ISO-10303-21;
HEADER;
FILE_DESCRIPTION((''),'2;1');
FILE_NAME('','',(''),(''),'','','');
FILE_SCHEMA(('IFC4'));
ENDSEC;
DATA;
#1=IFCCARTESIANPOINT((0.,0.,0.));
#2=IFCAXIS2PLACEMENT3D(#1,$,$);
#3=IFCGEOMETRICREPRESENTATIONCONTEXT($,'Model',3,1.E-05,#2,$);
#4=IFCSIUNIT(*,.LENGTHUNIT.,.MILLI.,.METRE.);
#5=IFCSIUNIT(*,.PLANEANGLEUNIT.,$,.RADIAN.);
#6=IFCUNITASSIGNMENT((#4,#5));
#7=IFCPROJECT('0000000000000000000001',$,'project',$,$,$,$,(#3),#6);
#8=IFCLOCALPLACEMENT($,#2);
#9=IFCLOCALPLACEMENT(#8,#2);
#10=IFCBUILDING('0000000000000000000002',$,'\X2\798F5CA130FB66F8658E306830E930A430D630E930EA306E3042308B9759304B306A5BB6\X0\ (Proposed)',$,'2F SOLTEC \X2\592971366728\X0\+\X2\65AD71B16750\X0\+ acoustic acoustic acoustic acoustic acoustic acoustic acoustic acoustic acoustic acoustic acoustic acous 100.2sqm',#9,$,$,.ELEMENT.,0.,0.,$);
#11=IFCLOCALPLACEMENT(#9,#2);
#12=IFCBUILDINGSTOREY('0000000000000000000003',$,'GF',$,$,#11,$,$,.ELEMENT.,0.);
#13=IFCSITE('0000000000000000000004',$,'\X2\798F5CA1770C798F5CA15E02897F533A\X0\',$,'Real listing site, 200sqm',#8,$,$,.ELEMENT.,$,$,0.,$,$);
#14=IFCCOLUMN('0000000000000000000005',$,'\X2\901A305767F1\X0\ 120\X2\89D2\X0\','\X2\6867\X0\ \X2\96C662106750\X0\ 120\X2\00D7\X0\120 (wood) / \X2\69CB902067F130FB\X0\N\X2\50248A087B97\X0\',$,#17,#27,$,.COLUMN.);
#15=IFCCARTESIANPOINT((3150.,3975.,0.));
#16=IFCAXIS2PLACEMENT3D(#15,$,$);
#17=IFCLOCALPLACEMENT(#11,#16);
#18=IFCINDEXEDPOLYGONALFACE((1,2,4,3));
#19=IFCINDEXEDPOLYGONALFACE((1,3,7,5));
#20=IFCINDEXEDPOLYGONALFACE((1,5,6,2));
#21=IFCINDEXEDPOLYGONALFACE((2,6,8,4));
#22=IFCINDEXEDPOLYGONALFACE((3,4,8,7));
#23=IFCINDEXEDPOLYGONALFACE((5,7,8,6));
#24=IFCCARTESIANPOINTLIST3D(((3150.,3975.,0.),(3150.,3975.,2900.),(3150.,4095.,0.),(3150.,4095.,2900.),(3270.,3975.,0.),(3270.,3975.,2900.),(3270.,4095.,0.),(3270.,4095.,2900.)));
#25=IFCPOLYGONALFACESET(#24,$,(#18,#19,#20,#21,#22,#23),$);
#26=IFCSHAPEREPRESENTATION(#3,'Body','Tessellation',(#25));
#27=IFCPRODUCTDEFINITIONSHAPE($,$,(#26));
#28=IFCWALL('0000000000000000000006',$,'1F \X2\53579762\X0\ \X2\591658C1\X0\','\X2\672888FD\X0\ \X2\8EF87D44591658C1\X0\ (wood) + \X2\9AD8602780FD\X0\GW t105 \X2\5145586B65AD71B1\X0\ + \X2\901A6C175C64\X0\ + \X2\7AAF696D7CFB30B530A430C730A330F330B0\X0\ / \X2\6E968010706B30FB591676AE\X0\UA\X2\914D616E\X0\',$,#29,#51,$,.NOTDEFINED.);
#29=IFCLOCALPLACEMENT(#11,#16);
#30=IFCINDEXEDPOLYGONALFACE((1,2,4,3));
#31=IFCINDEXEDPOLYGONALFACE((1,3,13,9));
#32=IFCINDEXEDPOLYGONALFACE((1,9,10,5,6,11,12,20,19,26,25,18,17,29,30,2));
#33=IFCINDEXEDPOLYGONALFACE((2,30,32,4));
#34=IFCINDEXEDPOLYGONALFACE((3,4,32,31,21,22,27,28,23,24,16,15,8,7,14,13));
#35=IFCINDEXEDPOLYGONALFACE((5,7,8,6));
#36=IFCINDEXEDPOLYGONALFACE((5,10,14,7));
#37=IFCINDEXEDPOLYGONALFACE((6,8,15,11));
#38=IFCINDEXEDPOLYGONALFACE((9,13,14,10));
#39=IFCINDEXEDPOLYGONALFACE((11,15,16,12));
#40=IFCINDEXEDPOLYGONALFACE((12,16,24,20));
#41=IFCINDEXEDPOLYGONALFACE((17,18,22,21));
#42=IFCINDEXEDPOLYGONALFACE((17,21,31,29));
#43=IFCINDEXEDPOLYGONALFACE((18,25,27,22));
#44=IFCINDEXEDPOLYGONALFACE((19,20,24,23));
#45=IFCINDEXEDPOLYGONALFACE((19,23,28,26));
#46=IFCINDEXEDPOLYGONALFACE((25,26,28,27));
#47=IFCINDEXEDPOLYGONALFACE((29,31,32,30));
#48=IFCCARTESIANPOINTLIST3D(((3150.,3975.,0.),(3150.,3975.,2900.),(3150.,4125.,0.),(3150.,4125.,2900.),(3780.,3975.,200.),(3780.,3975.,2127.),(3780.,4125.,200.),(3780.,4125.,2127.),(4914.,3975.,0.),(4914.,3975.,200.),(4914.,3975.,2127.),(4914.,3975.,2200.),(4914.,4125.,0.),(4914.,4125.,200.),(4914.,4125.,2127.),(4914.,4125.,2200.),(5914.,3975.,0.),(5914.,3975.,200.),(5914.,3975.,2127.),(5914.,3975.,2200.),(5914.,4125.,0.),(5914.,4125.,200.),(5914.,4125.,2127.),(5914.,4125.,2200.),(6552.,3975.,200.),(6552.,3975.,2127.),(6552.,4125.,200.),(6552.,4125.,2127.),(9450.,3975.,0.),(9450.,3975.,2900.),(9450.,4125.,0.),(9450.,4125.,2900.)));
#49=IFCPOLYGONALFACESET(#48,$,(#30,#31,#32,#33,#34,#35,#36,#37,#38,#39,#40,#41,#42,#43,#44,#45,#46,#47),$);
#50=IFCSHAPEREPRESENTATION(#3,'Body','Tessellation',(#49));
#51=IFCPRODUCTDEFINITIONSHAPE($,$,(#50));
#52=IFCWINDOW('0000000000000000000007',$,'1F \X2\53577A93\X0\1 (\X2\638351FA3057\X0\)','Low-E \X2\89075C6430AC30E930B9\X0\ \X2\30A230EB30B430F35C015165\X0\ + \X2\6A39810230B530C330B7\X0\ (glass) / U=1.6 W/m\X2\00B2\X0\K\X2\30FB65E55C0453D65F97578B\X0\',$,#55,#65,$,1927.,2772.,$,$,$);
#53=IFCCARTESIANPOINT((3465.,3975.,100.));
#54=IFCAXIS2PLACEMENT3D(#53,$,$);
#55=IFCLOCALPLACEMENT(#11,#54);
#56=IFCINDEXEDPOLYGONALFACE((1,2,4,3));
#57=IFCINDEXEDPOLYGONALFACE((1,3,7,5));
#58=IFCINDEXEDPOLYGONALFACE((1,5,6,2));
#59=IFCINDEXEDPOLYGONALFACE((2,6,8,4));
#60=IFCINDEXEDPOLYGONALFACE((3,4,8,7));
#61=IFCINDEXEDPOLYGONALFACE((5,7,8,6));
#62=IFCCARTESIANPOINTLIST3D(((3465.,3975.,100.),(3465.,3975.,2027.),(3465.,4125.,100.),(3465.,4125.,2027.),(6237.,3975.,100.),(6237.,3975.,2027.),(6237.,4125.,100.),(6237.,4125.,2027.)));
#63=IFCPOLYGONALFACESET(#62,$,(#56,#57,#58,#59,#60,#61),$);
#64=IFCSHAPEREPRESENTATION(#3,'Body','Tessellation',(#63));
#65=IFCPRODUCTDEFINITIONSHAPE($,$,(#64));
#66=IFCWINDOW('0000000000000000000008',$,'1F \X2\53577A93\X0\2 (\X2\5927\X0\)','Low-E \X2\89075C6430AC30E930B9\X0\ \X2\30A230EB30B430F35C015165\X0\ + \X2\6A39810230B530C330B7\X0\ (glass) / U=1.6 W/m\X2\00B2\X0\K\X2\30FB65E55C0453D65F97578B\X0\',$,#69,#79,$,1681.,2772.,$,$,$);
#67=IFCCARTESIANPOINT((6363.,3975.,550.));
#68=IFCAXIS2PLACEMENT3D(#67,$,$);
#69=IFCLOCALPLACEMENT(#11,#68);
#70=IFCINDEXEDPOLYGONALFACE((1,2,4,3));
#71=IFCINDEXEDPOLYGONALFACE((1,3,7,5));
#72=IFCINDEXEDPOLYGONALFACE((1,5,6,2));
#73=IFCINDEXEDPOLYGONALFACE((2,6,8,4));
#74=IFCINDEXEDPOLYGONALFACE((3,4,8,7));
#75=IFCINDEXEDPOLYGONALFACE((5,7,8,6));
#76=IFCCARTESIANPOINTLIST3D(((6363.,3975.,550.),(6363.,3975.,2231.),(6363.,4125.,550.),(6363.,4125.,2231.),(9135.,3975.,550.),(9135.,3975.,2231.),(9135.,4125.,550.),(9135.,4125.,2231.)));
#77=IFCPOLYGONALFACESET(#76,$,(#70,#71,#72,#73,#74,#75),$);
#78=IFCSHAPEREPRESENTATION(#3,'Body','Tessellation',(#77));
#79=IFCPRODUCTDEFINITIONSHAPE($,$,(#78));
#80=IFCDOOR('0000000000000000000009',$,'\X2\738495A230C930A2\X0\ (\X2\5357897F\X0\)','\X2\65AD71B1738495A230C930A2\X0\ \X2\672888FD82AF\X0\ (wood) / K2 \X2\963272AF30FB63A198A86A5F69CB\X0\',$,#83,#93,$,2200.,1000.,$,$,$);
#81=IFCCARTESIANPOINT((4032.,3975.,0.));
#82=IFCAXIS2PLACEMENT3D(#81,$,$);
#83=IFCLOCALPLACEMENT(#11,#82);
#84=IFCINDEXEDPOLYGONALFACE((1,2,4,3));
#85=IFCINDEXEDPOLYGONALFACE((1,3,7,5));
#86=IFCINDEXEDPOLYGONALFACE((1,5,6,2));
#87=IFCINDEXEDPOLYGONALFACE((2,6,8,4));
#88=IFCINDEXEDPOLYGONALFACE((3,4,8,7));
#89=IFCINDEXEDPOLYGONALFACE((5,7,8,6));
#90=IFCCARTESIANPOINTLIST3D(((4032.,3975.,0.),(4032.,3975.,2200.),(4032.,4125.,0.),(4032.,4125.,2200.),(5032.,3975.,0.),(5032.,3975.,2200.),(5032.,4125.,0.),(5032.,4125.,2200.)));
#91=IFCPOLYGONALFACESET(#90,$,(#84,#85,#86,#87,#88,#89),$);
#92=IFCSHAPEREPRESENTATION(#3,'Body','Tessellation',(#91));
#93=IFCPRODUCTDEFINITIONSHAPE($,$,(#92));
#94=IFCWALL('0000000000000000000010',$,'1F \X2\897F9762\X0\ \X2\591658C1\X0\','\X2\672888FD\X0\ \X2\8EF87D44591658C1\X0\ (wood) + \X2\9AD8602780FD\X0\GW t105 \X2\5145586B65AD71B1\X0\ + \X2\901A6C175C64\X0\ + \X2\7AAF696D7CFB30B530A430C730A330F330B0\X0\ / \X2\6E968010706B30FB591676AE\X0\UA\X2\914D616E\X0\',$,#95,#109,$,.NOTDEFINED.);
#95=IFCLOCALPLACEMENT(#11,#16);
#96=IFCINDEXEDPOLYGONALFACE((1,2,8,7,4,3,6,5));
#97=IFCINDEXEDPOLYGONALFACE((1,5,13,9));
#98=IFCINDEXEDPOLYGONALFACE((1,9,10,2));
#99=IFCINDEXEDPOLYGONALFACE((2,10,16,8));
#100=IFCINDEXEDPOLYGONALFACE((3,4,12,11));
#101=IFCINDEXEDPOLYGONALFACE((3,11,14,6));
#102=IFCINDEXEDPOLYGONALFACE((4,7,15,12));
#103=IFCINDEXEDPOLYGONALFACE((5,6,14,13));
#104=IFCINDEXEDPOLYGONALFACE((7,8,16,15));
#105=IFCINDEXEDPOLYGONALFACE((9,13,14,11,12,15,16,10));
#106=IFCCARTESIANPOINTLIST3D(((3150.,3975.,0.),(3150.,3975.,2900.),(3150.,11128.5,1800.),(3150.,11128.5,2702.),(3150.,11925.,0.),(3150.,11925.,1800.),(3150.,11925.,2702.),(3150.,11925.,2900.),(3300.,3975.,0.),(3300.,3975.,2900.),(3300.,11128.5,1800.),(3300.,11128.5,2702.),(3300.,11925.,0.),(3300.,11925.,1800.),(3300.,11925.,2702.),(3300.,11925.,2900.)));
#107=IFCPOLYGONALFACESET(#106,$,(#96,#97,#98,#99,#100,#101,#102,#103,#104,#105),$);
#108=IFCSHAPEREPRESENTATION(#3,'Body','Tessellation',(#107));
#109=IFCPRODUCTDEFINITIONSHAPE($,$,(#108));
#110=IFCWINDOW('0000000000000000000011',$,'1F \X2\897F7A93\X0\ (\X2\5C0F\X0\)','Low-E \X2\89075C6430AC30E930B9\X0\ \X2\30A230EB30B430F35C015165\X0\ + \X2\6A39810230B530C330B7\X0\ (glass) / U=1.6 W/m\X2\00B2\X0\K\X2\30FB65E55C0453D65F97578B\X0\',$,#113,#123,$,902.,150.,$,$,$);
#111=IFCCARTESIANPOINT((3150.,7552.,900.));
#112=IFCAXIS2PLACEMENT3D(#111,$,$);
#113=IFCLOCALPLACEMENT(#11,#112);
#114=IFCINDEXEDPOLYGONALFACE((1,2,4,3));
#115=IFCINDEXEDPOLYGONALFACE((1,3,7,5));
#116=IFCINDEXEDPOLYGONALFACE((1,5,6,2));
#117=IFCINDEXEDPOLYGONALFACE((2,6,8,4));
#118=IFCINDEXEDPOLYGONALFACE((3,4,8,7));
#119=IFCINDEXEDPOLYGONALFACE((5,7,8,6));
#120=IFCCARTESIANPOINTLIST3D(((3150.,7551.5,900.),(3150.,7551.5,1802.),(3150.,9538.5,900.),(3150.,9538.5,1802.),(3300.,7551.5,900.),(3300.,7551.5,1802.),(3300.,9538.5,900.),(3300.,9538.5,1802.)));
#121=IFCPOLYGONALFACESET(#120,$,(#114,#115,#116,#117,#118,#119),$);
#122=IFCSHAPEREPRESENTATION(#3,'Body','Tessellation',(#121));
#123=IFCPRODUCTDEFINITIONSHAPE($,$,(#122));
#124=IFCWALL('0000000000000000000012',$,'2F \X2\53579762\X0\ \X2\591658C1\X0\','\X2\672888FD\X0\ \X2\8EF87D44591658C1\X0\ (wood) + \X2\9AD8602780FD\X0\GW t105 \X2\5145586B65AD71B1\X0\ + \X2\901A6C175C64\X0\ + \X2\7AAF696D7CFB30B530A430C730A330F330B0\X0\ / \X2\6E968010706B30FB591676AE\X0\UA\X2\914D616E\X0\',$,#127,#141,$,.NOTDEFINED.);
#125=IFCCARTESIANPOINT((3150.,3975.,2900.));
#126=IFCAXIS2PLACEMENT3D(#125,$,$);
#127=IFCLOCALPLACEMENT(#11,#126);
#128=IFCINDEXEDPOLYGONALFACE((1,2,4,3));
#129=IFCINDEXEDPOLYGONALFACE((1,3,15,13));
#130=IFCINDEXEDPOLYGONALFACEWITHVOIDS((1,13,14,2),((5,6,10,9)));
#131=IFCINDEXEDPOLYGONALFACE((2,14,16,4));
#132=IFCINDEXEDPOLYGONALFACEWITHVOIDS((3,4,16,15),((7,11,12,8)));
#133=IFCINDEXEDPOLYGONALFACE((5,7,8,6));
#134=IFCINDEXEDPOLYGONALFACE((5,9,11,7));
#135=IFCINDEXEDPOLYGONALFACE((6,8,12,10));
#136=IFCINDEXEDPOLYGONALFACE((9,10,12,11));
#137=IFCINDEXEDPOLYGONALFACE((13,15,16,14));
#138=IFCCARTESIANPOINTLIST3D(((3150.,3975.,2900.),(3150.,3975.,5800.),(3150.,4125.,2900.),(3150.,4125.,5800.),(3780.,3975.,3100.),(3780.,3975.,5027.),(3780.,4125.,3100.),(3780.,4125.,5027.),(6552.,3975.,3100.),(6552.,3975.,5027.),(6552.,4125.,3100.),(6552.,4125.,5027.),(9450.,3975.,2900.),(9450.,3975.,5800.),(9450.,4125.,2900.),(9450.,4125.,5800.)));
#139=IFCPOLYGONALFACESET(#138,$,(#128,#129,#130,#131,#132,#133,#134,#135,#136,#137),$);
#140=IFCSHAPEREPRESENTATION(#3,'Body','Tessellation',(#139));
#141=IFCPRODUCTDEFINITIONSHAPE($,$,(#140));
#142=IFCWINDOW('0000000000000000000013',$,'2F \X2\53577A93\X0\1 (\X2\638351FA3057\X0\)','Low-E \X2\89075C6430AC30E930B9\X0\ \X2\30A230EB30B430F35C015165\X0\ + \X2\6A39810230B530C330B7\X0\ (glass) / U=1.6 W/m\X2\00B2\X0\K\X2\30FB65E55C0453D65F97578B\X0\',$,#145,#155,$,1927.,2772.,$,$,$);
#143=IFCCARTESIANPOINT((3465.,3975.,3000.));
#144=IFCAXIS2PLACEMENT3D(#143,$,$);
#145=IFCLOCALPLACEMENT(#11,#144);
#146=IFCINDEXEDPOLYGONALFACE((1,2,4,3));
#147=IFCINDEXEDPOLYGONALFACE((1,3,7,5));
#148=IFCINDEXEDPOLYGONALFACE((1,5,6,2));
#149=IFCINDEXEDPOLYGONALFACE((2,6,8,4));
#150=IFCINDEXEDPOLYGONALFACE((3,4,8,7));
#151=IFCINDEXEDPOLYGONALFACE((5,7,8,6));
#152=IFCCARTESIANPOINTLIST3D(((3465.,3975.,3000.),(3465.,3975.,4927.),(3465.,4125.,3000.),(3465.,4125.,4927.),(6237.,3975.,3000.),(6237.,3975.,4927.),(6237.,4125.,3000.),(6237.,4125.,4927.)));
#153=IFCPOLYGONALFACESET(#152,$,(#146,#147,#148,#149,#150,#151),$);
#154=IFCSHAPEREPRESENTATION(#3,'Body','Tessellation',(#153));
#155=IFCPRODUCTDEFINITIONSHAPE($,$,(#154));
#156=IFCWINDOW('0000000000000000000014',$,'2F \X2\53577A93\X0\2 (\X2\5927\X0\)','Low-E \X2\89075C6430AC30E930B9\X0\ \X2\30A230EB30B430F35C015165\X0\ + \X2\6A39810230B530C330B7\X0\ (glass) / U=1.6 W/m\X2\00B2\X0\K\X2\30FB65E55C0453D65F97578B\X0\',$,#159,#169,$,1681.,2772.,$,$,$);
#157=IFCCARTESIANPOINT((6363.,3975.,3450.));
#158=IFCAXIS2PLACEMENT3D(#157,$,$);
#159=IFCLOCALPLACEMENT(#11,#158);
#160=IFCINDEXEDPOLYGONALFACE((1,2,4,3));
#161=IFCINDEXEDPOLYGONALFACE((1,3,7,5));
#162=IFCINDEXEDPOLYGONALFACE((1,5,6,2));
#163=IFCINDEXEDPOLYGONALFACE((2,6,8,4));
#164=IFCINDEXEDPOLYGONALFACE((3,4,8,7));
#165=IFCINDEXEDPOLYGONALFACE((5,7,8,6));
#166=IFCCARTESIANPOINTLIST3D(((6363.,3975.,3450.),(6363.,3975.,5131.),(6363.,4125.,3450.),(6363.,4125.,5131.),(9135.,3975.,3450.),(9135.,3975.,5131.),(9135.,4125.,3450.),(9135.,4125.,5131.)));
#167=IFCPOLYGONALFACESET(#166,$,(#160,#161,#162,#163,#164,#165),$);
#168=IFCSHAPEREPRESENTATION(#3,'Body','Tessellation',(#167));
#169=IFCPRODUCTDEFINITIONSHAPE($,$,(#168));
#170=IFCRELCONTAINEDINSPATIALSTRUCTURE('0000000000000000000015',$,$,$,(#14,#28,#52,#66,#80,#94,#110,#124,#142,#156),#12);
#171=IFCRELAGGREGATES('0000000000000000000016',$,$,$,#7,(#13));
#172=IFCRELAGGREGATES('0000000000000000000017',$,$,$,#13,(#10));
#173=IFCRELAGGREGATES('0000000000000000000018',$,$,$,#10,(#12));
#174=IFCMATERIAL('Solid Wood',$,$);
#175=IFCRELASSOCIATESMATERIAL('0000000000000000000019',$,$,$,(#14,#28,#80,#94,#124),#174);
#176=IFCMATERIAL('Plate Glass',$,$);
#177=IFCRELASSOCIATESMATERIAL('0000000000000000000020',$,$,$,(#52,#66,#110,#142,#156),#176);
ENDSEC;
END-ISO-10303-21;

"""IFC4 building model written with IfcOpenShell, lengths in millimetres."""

from ifc_helpers import new_model, si_unit, frame, frame_2d, origin, place, context, project, spatial, rectangle, extrude, material, element, fill, save


model = new_model("IFC4")

# Units and contexts
model_context = context("Model", 3, precision=1e-05, world=origin())
ifc_project = project(units=[si_unit("LENGTHUNIT", "METRE", prefix="MILLI"), si_unit("PLANEANGLEUNIT", "RADIAN")], contexts=[model_context])

# Site, building, storey
site_placement = place(None, origin())
site = spatial("IfcSite", under=ifc_project, at=site_placement, Name="福岡県福岡市西区", ObjectType="Real listing site, 200sqm", CompositionType="ELEMENT", RefElevation=0.0)
building_placement = place(site_placement, origin())
building = spatial("IfcBuilding", under=site, at=building_placement, Name="福岡・書斎とライブラリのある静かな家 (Proposed)", ObjectType="2F SOLTEC 天然木+断熱材+ acoustic acoustic acoustic acoustic acoustic acoustic acoustic acoustic acoustic acoustic acoustic acous 100.2sqm", CompositionType="ELEMENT", ElevationOfRefHeight=0.0, ElevationOfTerrain=0.0)
storey_placement = place(building_placement, origin())
storey = spatial("IfcBuildingStorey", under=building, at=storey_placement, Name="GF", CompositionType="ELEMENT", Elevation=0.0)

# Column
ifc_material_1 = material(Name="Solid Wood")
column_placement = place(storey_placement, frame((3150.0, 3975.0, 0.0)))
element("IfcColumn", 1, at=column_placement, inside=storey, material=ifc_material_1, Name="通し柱 120角", Description="桧 集成材 120×120 (wood) / 構造柱・N値計算", PredefinedType="COLUMN", context=model_context, shape_type="SweptSolid", body=[
    extrude(rectangle(XDim=120.0, YDim=120.0, at=frame_2d((60.0, 60.0))), frame((3150.0, 3975.0, 0.0)), (0.0, 0.0, 1.0), 2900.0),
])

# Wall, openings, windows, door
wall_1_placement = place(storey_placement, frame((3150.0, 3975.0, 0.0)))
wall_1 = element("IfcWall", 2, at=wall_1_placement, inside=storey, material=ifc_material_1, Name="1F 南面 外壁", Description="木製 軸組外壁 (wood) + 高性能GW t105 充填断熱 + 通気層 + 窯業系サイディング / 準耐火・外皮UA配慮", PredefinedType="NOTDEFINED", context=model_context, shape_type="SweptSolid", body=[
    extrude(rectangle(XDim=6300.0, YDim=150.0, at=frame_2d((3150.0, 75.0))), frame((3150.0, 3975.0, 0.0)), (0.0, 0.0, 1.0), 2900.0),
])
opening_1_placement = place(storey_placement, frame((3465.0, 3975.0, 100.0)))
opening_1 = element("IfcOpeningElement", 3, at=opening_1_placement, cuts=wall_1, PredefinedType="NOTDEFINED", context=model_context, shape_type="SweptSolid", body=[
    extrude(rectangle(XDim=2772.0, YDim=150.0, at=frame_2d((1386.0, 75.0))), frame((3465.0, 3975.0, 100.0)), (0.0, 0.0, 1.0), 1927.0),
])
opening_2_placement = place(storey_placement, frame((6363.0, 3975.0, 550.0)))
opening_2 = element("IfcOpeningElement", 4, at=opening_2_placement, cuts=wall_1, PredefinedType="NOTDEFINED", context=model_context, shape_type="SweptSolid", body=[
    extrude(rectangle(XDim=2772.0, YDim=150.0, at=frame_2d((1386.0, 75.0))), frame((6363.0, 3975.0, 550.0)), (0.0, 0.0, 1.0), 1681.0),
])
opening_3_placement = place(storey_placement, frame((4032.0, 3975.0, 0.0)))
opening_3 = element("IfcOpeningElement", 5, at=opening_3_placement, cuts=wall_1, PredefinedType="NOTDEFINED", context=model_context, shape_type="SweptSolid", body=[
    extrude(rectangle(XDim=1000.0, YDim=150.0, at=frame_2d((500.0, 75.0))), frame((4032.0, 3975.0, 0.0)), (0.0, 0.0, 1.0), 2200.0),
])
ifc_material_2 = material(Name="Plate Glass")
window_1_placement = place(storey_placement, frame((3465.0, 3975.0, 100.0)))
window_1 = element("IfcWindow", 6, at=window_1_placement, inside=storey, material=ifc_material_2, Name="1F 南窓1 (掃出し)", Description="Low-E 複層ガラス アルゴン封入 + 樹脂サッシ (glass) / U=1.6 W/m²K・日射取得型", OverallHeight=1927.0, OverallWidth=2772.0, context=model_context, shape_type="SweptSolid", body=[
    extrude(rectangle(XDim=2772.0, YDim=150.0, at=frame_2d((1386.0, 75.0))), frame((3465.0, 3975.0, 100.0)), (0.0, 0.0, 1.0), 1927.0),
])
fill(opening_1, window_1)
window_2_placement = place(storey_placement, frame((6363.0, 3975.0, 550.0)))
window_2 = element("IfcWindow", 7, at=window_2_placement, inside=storey, material=ifc_material_2, Name="1F 南窓2 (大)", Description="Low-E 複層ガラス アルゴン封入 + 樹脂サッシ (glass) / U=1.6 W/m²K・日射取得型", OverallHeight=1681.0, OverallWidth=2772.0, context=model_context, shape_type="SweptSolid", body=[
    extrude(rectangle(XDim=2772.0, YDim=150.0, at=frame_2d((1386.0, 75.0))), frame((6363.0, 3975.0, 550.0)), (0.0, 0.0, 1.0), 1681.0),
])
fill(opening_2, window_2)
door_placement = place(storey_placement, frame((4032.0, 3975.0, 0.0)))
door = element("IfcDoor", 8, at=door_placement, inside=storey, material=ifc_material_1, Name="玄関ドア (南西)", Description="断熱玄関ドア 木製芯 (wood) / K2 防犯・採風機構", OverallHeight=2200.0, OverallWidth=1000.0, context=model_context, shape_type="SweptSolid", body=[
    extrude(rectangle(XDim=1000.0, YDim=150.0, at=frame_2d((500.0, 75.0))), frame((4032.0, 3975.0, 0.0)), (0.0, 0.0, 1.0), 2200.0),
])
fill(opening_3, door)

# Wall, opening, window
wall_2_placement = place(storey_placement, frame((3150.0, 3975.0, 0.0)))
wall_2 = element("IfcWall", 9, at=wall_2_placement, inside=storey, material=ifc_material_1, Name="1F 西面 外壁", Description="木製 軸組外壁 (wood) + 高性能GW t105 充填断熱 + 通気層 + 窯業系サイディング / 準耐火・外皮UA配慮", PredefinedType="NOTDEFINED", context=model_context, shape_type="SweptSolid", body=[
    extrude(rectangle(XDim=150.0, YDim=7950.0, at=frame_2d((75.0, 3975.0))), frame((3150.0, 3975.0, 0.0)), (0.0, 0.0, 1.0), 2900.0),
])
opening_4_placement = place(storey_placement, frame((3150.0, 7552.0, 900.0)))
opening_4 = element("IfcOpeningElement", 10, at=opening_4_placement, cuts=wall_2, PredefinedType="NOTDEFINED", context=model_context, shape_type="SweptSolid", body=[
    extrude(rectangle(XDim=150.0, YDim=1987.0, at=frame_2d((75.0, 993.0))), frame((3150.0, 7552.0, 900.0)), (0.0, 0.0, 1.0), 902.0),
])
window_3_placement = place(storey_placement, frame((3150.0, 7552.0, 900.0)))
window_3 = element("IfcWindow", 11, at=window_3_placement, inside=storey, material=ifc_material_2, Name="1F 西窓 (小)", Description="Low-E 複層ガラス アルゴン封入 + 樹脂サッシ (glass) / U=1.6 W/m²K・日射取得型", OverallHeight=902.0, OverallWidth=150.0, context=model_context, shape_type="SweptSolid", body=[
    extrude(rectangle(XDim=150.0, YDim=1987.0, at=frame_2d((75.0, 993.0))), frame((3150.0, 7552.0, 900.0)), (0.0, 0.0, 1.0), 902.0),
])
fill(opening_4, window_3)

# Wall, openings, windows
wall_3_placement = place(storey_placement, frame((3150.0, 3975.0, 2900.0)))
wall_3 = element("IfcWall", 12, at=wall_3_placement, inside=storey, material=ifc_material_1, Name="2F 南面 外壁", Description="木製 軸組外壁 (wood) + 高性能GW t105 充填断熱 + 通気層 + 窯業系サイディング / 準耐火・外皮UA配慮", PredefinedType="NOTDEFINED", context=model_context, shape_type="SweptSolid", body=[
    extrude(rectangle(XDim=6300.0, YDim=150.0, at=frame_2d((3150.0, 75.0))), frame((3150.0, 3975.0, 2900.0)), (0.0, 0.0, 1.0), 2900.0),
])
opening_5_placement = place(storey_placement, frame((3465.0, 3975.0, 3000.0)))
opening_5 = element("IfcOpeningElement", 13, at=opening_5_placement, cuts=wall_3, PredefinedType="NOTDEFINED", context=model_context, shape_type="SweptSolid", body=[
    extrude(rectangle(XDim=2772.0, YDim=150.0, at=frame_2d((1386.0, 75.0))), frame((3465.0, 3975.0, 3000.0)), (0.0, 0.0, 1.0), 1927.0),
])
opening_6_placement = place(storey_placement, frame((6363.0, 3975.0, 3450.0)))
opening_6 = element("IfcOpeningElement", 14, at=opening_6_placement, cuts=wall_3, PredefinedType="NOTDEFINED", context=model_context, shape_type="SweptSolid", body=[
    extrude(rectangle(XDim=2772.0, YDim=150.0, at=frame_2d((1386.0, 75.0))), frame((6363.0, 3975.0, 3450.0)), (0.0, 0.0, 1.0), 1681.0),
])
window_4_placement = place(storey_placement, frame((3465.0, 3975.0, 3000.0)))
window_4 = element("IfcWindow", 15, at=window_4_placement, inside=storey, material=ifc_material_2, Name="2F 南窓1 (掃出し)", Description="Low-E 複層ガラス アルゴン封入 + 樹脂サッシ (glass) / U=1.6 W/m²K・日射取得型", OverallHeight=1927.0, OverallWidth=2772.0, context=model_context, shape_type="SweptSolid", body=[
    extrude(rectangle(XDim=2772.0, YDim=150.0, at=frame_2d((1386.0, 75.0))), frame((3465.0, 3975.0, 3000.0)), (0.0, 0.0, 1.0), 1927.0),
])
fill(opening_5, window_4)
window_5_placement = place(storey_placement, frame((6363.0, 3975.0, 3450.0)))
window_5 = element("IfcWindow", 16, at=window_5_placement, inside=storey, material=ifc_material_2, Name="2F 南窓2 (大)", Description="Low-E 複層ガラス アルゴン封入 + 樹脂サッシ (glass) / U=1.6 W/m²K・日射取得型", OverallHeight=1681.0, OverallWidth=2772.0, context=model_context, shape_type="SweptSolid", body=[
    extrude(rectangle(XDim=2772.0, YDim=150.0, at=frame_2d((1386.0, 75.0))), frame((6363.0, 3975.0, 3450.0)), (0.0, 0.0, 1.0), 1681.0),
])
fill(opening_6, window_5)

save(model, "model.ifc")
